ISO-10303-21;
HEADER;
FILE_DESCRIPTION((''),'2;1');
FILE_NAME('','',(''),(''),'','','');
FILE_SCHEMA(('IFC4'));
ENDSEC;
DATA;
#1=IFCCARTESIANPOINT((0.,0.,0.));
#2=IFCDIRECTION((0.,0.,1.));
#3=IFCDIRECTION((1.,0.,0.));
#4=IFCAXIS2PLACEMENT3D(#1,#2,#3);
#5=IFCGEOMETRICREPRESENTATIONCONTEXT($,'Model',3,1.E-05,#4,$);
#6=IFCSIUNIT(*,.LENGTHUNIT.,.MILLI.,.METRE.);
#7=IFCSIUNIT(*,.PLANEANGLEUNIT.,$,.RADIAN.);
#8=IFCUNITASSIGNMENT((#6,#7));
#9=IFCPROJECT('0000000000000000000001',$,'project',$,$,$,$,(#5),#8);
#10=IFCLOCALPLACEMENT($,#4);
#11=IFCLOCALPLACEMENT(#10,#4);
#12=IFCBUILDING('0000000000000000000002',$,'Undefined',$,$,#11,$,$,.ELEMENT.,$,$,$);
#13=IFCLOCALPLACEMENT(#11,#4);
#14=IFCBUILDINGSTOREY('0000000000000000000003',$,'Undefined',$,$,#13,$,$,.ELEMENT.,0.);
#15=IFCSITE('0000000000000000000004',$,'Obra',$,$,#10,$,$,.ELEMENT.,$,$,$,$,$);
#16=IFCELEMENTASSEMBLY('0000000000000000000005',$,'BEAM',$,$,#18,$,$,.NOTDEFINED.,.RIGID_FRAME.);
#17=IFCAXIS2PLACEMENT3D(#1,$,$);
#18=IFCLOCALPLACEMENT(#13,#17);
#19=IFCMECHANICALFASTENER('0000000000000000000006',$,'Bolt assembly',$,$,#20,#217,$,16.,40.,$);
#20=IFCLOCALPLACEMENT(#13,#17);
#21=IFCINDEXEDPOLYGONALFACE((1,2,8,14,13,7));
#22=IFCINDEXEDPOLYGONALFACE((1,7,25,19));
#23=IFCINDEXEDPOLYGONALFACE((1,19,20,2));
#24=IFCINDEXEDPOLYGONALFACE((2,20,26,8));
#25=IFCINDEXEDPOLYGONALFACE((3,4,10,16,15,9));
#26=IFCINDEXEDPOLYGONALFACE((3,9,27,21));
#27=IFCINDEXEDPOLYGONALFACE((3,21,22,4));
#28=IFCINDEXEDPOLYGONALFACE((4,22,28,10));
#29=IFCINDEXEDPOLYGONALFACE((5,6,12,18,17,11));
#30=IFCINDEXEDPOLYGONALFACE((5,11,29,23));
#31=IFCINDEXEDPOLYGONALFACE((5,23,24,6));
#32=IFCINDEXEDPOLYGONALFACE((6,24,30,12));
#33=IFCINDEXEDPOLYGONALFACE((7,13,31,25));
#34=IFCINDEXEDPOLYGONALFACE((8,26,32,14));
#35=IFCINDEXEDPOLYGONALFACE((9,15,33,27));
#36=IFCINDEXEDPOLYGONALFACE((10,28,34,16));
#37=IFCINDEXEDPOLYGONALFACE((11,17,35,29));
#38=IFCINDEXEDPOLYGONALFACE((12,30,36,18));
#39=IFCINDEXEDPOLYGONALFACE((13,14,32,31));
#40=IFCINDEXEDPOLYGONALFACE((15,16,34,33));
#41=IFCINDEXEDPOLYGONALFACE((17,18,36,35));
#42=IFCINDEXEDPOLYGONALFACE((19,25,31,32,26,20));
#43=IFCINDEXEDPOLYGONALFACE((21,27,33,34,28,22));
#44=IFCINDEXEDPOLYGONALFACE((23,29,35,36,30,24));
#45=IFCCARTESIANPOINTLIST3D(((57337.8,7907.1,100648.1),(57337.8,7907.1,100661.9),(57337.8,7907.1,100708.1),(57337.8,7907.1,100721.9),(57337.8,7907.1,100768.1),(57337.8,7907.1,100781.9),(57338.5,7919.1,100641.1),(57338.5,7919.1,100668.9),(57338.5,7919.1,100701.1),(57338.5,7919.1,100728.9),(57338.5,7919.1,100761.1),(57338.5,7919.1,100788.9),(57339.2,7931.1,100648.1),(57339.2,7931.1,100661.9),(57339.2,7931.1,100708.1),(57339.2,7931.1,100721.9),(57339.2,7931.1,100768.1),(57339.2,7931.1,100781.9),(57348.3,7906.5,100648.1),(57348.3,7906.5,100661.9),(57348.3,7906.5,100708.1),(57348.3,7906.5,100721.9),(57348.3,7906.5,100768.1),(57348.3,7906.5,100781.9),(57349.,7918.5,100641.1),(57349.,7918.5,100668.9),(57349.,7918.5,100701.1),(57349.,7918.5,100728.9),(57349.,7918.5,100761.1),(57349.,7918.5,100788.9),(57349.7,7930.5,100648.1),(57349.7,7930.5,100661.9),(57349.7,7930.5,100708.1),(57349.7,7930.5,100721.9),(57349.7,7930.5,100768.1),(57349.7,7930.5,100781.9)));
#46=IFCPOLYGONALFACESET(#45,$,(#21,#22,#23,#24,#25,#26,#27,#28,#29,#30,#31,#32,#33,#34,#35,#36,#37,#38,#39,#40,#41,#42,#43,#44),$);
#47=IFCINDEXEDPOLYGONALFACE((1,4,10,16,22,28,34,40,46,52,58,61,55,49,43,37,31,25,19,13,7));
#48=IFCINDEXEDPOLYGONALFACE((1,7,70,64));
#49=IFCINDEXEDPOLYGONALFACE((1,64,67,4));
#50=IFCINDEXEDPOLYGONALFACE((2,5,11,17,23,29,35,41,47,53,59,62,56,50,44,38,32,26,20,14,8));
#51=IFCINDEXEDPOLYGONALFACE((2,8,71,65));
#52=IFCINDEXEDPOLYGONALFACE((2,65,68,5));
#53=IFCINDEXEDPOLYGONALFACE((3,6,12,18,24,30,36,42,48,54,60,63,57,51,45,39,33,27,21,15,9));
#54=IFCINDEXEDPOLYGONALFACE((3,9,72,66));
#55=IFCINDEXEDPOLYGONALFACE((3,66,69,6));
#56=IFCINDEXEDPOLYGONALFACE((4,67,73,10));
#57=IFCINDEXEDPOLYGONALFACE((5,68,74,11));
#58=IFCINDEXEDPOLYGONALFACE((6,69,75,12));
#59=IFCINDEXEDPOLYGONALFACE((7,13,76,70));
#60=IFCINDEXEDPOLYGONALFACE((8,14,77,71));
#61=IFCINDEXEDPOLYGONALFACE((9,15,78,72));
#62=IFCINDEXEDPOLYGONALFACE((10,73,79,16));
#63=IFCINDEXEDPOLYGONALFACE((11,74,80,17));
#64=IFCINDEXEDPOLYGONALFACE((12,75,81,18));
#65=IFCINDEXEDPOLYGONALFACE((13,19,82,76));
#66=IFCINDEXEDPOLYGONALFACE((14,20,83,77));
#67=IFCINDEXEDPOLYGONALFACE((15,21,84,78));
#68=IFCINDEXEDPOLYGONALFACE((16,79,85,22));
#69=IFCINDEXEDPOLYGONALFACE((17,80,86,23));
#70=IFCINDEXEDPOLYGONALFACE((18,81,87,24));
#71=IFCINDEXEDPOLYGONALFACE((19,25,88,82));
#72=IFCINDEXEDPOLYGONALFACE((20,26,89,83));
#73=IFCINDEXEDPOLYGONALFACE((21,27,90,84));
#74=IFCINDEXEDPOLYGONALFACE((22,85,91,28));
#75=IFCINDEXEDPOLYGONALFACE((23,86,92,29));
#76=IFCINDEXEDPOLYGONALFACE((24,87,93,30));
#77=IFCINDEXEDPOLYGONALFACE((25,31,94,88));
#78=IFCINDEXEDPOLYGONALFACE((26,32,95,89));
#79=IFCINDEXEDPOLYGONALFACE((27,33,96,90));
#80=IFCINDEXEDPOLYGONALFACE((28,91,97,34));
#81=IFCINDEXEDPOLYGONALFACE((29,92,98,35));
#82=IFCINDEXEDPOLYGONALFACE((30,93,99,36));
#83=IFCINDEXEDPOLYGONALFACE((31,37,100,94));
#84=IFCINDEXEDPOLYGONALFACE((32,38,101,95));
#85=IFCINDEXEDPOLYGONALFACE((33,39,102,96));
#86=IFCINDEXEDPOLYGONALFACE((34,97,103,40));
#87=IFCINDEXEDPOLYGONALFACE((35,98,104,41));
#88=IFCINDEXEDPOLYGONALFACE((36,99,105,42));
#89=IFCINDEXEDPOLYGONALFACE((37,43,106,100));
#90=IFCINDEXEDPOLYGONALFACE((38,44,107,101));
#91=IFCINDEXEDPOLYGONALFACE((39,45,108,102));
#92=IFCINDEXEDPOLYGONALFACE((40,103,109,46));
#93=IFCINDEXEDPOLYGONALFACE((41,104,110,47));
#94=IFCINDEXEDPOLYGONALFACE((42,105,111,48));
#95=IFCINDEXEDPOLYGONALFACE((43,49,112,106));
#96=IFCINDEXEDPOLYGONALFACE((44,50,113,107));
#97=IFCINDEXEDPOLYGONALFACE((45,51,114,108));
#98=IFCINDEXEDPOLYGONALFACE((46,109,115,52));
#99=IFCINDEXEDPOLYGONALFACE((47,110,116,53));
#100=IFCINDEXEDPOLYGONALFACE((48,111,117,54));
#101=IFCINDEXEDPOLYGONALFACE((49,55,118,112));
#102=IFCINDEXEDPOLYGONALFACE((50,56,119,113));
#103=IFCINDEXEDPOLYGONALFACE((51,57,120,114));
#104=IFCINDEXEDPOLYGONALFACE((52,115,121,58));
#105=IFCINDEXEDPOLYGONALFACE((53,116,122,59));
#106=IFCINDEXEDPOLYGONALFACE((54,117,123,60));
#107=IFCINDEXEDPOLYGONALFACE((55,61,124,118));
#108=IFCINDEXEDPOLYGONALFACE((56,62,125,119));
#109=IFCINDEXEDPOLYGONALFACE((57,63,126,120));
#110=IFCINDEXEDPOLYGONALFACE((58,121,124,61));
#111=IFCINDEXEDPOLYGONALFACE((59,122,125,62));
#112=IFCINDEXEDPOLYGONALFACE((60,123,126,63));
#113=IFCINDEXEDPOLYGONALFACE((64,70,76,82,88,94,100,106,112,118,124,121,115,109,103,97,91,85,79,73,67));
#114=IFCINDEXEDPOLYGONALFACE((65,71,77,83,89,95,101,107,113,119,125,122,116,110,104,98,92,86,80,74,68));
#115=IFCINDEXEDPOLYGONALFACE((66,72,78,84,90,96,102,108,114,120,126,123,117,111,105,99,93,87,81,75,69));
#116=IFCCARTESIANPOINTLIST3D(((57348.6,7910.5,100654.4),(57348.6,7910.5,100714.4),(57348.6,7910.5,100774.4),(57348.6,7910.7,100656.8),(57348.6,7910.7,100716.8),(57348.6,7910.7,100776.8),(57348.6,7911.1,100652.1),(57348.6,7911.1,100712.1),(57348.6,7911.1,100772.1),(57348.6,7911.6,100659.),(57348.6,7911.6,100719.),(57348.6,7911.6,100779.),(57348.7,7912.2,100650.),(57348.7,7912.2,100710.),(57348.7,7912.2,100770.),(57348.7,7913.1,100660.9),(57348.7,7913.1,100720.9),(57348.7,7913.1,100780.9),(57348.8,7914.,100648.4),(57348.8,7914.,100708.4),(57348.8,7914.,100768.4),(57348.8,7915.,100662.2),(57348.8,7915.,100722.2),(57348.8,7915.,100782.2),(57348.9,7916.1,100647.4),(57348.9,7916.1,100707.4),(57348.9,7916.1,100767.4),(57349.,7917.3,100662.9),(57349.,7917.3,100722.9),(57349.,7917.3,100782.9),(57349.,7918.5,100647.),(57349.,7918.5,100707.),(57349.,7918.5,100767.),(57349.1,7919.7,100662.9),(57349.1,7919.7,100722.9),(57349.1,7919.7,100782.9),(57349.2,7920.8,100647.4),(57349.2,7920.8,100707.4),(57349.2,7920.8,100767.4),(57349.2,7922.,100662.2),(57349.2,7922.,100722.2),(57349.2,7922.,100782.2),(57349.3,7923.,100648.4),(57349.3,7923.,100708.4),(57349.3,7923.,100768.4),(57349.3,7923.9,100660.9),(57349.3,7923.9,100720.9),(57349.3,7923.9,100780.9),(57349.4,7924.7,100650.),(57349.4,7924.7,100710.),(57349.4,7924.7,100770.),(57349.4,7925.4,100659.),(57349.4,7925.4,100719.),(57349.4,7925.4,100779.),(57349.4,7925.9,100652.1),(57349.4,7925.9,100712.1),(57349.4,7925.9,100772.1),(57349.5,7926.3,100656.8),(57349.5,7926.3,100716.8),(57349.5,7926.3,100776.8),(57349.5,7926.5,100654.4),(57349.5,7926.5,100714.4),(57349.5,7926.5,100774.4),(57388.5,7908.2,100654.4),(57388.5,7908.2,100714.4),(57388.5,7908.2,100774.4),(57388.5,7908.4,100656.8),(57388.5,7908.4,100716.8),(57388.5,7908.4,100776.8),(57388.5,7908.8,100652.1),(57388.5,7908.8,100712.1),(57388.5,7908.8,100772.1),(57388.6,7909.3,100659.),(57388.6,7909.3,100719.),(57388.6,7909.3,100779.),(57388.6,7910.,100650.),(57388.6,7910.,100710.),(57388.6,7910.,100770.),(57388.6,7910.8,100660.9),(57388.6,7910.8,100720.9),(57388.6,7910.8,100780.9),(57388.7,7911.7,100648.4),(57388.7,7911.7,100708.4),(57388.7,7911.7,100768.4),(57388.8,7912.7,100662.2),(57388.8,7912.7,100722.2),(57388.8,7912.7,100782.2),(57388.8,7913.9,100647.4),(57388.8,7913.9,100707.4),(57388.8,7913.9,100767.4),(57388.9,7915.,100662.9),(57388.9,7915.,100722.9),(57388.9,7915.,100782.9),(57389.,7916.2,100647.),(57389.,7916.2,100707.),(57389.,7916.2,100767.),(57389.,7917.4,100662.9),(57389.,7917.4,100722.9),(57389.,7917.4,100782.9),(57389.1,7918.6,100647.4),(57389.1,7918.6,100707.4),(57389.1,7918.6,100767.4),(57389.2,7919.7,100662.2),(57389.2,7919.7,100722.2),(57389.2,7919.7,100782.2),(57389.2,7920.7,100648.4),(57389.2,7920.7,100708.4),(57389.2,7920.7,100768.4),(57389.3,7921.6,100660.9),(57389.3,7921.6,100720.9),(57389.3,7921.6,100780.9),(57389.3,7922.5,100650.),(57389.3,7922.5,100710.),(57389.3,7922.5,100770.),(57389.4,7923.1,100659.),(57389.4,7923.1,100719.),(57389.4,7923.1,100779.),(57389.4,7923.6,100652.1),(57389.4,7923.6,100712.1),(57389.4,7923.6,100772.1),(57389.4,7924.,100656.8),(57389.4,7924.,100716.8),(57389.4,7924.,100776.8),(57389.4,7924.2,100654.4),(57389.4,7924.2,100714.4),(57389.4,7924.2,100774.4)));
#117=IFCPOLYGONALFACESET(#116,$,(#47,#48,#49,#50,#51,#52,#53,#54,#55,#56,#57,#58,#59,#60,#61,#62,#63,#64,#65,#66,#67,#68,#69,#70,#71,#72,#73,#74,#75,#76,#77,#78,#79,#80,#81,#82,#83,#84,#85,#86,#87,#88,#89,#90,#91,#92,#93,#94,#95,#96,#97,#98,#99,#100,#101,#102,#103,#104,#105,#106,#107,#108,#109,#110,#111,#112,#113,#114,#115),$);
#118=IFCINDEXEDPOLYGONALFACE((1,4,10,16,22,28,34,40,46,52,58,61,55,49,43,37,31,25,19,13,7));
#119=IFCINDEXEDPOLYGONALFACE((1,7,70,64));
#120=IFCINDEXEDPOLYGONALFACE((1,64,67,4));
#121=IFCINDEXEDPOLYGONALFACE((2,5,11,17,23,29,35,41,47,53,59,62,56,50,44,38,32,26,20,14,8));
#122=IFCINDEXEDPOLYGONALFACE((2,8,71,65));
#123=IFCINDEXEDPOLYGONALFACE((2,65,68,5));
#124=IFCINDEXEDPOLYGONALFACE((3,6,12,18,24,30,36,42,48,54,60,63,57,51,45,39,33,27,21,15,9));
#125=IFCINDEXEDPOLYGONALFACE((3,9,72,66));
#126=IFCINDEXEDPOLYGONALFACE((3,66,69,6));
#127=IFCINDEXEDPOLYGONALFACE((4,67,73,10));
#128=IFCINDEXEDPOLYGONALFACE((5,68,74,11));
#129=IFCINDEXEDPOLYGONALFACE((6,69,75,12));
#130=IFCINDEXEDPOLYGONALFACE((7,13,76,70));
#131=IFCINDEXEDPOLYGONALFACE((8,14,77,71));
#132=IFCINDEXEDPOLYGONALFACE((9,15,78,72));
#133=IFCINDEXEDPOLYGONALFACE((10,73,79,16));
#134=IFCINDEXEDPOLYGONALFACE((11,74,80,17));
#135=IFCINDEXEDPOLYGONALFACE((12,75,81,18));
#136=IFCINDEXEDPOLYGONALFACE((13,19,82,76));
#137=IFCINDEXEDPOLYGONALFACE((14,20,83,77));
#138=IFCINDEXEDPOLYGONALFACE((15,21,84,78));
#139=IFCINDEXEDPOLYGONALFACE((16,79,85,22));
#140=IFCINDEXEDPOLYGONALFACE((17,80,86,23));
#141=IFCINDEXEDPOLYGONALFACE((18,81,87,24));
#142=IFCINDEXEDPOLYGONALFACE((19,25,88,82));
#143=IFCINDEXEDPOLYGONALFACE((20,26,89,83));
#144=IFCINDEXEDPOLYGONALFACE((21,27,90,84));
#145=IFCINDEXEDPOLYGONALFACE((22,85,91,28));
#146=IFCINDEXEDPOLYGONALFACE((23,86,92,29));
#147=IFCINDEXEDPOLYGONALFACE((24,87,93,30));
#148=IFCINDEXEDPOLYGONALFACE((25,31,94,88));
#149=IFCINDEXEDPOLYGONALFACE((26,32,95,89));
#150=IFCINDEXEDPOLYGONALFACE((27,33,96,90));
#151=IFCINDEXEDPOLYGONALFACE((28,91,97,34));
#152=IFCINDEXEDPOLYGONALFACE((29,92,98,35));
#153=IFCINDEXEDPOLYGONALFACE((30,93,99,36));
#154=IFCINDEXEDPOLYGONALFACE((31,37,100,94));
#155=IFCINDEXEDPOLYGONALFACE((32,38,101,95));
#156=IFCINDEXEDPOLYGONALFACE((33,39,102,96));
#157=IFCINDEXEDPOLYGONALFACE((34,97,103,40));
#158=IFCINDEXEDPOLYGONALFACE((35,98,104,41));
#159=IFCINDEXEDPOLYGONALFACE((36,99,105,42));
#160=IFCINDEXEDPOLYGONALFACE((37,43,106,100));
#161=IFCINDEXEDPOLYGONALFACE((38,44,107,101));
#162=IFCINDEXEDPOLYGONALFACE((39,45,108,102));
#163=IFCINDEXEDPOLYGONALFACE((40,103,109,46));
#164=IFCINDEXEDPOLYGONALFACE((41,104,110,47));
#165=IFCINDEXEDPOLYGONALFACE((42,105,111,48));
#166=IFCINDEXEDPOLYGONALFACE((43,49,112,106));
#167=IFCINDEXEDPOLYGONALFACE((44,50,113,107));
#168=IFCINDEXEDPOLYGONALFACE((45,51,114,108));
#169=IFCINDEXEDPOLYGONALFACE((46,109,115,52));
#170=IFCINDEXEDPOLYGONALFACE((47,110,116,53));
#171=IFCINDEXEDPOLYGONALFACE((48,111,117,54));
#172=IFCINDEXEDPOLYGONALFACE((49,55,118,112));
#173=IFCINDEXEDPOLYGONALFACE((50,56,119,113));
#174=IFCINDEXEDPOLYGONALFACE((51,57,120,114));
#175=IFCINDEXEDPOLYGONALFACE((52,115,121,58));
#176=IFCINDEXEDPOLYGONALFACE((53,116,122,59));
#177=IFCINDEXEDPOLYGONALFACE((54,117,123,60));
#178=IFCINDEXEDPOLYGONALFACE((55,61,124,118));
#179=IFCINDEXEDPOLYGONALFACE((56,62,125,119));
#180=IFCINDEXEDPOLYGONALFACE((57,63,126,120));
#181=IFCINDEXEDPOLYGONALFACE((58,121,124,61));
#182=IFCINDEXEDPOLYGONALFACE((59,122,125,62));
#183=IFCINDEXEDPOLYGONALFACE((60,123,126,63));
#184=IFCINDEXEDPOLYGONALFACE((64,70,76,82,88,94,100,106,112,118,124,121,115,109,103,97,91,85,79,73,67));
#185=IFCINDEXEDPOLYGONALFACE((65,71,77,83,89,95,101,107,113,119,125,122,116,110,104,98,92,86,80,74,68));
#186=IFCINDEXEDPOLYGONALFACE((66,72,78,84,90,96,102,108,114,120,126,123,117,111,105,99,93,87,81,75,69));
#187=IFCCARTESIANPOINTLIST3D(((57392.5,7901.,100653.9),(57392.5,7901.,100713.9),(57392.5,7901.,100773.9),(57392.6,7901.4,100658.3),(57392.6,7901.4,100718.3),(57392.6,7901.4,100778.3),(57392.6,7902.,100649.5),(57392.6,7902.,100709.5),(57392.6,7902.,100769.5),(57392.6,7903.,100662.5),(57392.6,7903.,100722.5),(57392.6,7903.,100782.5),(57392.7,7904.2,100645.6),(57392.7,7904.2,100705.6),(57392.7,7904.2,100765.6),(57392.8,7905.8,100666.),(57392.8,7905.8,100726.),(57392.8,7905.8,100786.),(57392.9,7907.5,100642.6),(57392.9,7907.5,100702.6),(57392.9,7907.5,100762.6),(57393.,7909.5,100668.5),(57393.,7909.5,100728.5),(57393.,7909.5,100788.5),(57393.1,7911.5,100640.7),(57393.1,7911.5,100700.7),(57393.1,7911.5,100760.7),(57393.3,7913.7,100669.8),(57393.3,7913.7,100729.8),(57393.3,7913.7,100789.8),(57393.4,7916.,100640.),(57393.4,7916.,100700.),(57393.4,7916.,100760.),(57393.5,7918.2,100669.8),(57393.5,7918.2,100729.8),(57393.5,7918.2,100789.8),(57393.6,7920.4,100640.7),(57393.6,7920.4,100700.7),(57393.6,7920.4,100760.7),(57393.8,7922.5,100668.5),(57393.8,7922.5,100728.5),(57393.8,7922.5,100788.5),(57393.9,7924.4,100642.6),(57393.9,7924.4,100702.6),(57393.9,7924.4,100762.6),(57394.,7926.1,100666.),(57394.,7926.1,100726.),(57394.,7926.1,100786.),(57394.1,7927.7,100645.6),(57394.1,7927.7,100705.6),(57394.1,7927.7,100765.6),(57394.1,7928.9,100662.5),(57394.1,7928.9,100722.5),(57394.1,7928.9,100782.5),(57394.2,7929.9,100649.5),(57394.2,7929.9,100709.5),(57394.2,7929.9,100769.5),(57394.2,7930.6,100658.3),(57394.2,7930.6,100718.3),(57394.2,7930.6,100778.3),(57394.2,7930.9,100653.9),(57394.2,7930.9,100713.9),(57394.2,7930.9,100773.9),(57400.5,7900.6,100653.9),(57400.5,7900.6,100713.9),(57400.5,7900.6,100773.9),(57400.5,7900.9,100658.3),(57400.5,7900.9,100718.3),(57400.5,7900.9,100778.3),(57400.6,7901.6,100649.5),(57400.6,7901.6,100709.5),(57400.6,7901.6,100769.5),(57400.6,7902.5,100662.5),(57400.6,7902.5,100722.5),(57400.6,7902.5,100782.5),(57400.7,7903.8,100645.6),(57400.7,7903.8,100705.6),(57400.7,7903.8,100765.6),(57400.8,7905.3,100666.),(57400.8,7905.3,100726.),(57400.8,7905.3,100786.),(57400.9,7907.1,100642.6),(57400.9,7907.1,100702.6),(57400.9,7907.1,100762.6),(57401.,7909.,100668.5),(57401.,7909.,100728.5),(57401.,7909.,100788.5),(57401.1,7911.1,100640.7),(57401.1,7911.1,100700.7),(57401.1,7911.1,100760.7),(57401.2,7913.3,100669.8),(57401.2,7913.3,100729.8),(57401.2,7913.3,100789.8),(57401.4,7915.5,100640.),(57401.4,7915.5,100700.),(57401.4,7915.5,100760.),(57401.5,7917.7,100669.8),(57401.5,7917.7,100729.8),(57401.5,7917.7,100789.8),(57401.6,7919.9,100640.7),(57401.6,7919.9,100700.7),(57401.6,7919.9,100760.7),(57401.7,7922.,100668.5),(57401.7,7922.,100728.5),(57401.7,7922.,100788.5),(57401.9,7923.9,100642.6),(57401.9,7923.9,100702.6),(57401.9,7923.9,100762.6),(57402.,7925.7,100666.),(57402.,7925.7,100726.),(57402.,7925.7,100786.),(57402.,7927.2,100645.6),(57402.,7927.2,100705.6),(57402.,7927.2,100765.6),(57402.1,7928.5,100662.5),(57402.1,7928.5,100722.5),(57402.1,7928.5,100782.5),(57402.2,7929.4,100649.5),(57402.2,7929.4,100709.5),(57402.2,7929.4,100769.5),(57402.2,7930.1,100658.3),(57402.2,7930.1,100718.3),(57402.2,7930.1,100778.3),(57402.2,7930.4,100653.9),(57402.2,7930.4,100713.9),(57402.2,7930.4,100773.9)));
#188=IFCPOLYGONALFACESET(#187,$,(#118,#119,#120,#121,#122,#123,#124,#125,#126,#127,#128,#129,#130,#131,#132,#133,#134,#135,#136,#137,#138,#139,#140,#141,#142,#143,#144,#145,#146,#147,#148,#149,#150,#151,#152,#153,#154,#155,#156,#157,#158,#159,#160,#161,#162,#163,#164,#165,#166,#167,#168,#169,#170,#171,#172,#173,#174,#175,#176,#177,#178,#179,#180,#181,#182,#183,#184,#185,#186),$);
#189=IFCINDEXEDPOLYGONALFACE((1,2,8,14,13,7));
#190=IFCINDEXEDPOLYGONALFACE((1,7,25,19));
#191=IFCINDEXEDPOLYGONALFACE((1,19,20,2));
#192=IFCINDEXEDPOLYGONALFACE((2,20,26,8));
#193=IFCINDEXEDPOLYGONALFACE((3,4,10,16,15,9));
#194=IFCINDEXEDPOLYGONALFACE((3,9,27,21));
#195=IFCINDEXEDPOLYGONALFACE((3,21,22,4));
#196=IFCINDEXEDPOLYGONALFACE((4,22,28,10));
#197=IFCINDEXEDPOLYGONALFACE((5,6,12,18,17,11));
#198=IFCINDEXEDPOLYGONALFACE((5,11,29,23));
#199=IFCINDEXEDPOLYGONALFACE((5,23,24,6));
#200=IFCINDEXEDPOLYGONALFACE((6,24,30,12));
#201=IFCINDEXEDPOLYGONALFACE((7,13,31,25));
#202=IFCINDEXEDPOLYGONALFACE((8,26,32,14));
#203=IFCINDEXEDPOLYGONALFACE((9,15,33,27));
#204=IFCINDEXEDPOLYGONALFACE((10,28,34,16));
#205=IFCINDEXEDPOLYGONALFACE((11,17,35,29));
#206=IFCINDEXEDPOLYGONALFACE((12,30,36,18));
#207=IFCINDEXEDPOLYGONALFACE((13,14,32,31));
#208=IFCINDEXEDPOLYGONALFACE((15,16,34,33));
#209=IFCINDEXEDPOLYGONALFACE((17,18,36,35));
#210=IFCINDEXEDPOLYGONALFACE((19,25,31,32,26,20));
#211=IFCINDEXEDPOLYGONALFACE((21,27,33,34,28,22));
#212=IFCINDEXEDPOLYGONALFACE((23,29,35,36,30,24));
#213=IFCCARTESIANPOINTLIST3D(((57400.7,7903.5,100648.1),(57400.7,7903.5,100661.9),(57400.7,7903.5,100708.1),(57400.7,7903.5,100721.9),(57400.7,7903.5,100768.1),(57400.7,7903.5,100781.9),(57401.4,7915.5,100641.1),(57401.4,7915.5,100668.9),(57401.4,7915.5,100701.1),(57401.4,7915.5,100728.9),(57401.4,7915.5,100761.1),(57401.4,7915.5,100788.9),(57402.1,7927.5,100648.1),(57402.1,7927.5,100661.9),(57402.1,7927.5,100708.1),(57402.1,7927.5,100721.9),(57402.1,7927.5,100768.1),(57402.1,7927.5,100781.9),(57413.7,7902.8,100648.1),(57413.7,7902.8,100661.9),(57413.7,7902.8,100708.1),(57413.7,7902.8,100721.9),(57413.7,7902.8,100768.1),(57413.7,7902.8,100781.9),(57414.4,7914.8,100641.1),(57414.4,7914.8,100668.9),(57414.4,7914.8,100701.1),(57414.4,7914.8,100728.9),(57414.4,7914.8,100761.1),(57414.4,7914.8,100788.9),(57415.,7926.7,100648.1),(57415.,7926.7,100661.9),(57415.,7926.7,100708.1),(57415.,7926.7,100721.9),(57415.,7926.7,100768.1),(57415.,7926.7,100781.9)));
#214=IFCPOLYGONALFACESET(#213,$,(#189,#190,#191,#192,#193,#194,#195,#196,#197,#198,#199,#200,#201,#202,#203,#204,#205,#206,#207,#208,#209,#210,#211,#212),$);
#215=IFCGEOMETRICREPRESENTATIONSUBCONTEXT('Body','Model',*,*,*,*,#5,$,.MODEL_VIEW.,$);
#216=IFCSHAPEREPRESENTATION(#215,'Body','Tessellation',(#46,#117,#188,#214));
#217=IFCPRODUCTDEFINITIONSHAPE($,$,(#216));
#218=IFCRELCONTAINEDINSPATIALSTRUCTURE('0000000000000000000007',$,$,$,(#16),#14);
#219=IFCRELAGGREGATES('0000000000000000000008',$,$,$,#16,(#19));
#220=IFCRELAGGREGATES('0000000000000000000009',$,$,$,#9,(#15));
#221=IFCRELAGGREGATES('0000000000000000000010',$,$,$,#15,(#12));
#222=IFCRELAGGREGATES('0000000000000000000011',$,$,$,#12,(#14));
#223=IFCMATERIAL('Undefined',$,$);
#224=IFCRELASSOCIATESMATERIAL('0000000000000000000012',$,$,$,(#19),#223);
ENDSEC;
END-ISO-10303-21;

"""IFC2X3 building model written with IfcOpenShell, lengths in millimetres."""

from ifc_helpers import new_model, si_unit, frame, origin_with_axes, origin_2d_with_axis, place, context, subcontext, project, spatial, polyline, circle, outline, extrude, source, transform, mapped, material, element, aggregate, save


model = new_model("IFC2X3")

# Units and contexts
model_context = context("Model", 3, precision=1e-05, world=origin_with_axes())
body_context = subcontext(model_context, "Body", "Model", "MODEL_VIEW")
ifc_project = project(units=[si_unit("LENGTHUNIT", "METRE", prefix="MILLI"), si_unit("PLANEANGLEUNIT", "RADIAN")], contexts=[model_context])

# Site, building, storey
site_placement = place(None, origin_with_axes())
site = spatial("IfcSite", under=ifc_project, at=site_placement, Name="Obra", CompositionType="ELEMENT")
building_placement = place(site_placement, origin_with_axes())
building = spatial("IfcBuilding", under=site, at=building_placement, Name="Undefined", CompositionType="ELEMENT")
storey_placement = place(building_placement, origin_with_axes())
storey = spatial("IfcBuildingStorey", under=building, at=storey_placement, Name="Undefined", CompositionType="ELEMENT", Elevation=0.0)

# Shared definitions
ifc_material_1 = material(Name="Undefined")

# Element assembly
assembly_1_placement = place(storey_placement, origin_with_axes())
assembly_1 = element("IfcElementAssembly", 1, at=assembly_1_placement, inside=storey, Name="BEAM", AssemblyPlace="NOTDEFINED", PredefinedType="RIGID_FRAME")

# Shared definitions
shared_shape_1 = source(origin_with_axes(), body_context, "Body", "SweptSolid", [
    extrude(outline(polyline([(13.9, 0.0), (6.9, 12.0), (-6.9, 12.0), (-13.9, 0.0), (-6.9, -12.0), (6.9, -12.0), (13.9, 0.0)])), frame((0.0, -19.7, 0.0), z_axis=(0.0, 1.0, 0.0), x_axis=(1.0, 0.0, 0.0)), (0.0, 0.0, 1.0), 10.6),
    extrude(circle(Radius=8.0, at=origin_2d_with_axis()), frame((0.0, -9.1, 0.0), z_axis=(0.0, 1.0, 0.0), x_axis=(1.0, 0.0, 0.0)), (0.0, 0.0, 1.0), 40.0),
    extrude(circle(Radius=15.0, at=origin_2d_with_axis()), frame((0.0, 35.3, 0.0), z_axis=(0.0, 1.0, 0.0), x_axis=(1.0, 0.0, 0.0)), (0.0, 0.0, 1.0), 8.0),
    extrude(outline(polyline([(13.9, 0.0), (6.9, 12.0), (-6.9, 12.0), (-13.9, 0.0), (-6.9, -12.0), (6.9, -12.0), (13.9, 0.0)])), frame((0.0, 43.3, 0.0), z_axis=(0.0, 1.0, 0.0), x_axis=(1.0, 0.0, 0.0)), (0.0, 0.0, 1.0), 13.0),
])

# Mechanical fastener
mechanical_fastener_1_placement = place(assembly_1_placement, frame((57361.0, 7967.9, 100835.0), z_axis=(-0.05711, -0.998368, 0.0), x_axis=(0.0, 0.0, -1.0)))
mechanical_fastener_1 = element("IfcMechanicalFastener", 2, at=mechanical_fastener_1_placement, material=ifc_material_1, Name="Bolt assembly", NominalDiameter=16.0, NominalLength=40.0, context=body_context, shape_type="MappedRepresentation", body=[
    mapped(shared_shape_1, transform((60.0, 0.0, 50.0))),
    mapped(shared_shape_1, transform((120.0, 0.0, 50.0))),
    mapped(shared_shape_1, transform((180.0, 0.0, 50.0))),
])
aggregate(assembly_1, [mechanical_fastener_1])

save(model, "model.ifc")
